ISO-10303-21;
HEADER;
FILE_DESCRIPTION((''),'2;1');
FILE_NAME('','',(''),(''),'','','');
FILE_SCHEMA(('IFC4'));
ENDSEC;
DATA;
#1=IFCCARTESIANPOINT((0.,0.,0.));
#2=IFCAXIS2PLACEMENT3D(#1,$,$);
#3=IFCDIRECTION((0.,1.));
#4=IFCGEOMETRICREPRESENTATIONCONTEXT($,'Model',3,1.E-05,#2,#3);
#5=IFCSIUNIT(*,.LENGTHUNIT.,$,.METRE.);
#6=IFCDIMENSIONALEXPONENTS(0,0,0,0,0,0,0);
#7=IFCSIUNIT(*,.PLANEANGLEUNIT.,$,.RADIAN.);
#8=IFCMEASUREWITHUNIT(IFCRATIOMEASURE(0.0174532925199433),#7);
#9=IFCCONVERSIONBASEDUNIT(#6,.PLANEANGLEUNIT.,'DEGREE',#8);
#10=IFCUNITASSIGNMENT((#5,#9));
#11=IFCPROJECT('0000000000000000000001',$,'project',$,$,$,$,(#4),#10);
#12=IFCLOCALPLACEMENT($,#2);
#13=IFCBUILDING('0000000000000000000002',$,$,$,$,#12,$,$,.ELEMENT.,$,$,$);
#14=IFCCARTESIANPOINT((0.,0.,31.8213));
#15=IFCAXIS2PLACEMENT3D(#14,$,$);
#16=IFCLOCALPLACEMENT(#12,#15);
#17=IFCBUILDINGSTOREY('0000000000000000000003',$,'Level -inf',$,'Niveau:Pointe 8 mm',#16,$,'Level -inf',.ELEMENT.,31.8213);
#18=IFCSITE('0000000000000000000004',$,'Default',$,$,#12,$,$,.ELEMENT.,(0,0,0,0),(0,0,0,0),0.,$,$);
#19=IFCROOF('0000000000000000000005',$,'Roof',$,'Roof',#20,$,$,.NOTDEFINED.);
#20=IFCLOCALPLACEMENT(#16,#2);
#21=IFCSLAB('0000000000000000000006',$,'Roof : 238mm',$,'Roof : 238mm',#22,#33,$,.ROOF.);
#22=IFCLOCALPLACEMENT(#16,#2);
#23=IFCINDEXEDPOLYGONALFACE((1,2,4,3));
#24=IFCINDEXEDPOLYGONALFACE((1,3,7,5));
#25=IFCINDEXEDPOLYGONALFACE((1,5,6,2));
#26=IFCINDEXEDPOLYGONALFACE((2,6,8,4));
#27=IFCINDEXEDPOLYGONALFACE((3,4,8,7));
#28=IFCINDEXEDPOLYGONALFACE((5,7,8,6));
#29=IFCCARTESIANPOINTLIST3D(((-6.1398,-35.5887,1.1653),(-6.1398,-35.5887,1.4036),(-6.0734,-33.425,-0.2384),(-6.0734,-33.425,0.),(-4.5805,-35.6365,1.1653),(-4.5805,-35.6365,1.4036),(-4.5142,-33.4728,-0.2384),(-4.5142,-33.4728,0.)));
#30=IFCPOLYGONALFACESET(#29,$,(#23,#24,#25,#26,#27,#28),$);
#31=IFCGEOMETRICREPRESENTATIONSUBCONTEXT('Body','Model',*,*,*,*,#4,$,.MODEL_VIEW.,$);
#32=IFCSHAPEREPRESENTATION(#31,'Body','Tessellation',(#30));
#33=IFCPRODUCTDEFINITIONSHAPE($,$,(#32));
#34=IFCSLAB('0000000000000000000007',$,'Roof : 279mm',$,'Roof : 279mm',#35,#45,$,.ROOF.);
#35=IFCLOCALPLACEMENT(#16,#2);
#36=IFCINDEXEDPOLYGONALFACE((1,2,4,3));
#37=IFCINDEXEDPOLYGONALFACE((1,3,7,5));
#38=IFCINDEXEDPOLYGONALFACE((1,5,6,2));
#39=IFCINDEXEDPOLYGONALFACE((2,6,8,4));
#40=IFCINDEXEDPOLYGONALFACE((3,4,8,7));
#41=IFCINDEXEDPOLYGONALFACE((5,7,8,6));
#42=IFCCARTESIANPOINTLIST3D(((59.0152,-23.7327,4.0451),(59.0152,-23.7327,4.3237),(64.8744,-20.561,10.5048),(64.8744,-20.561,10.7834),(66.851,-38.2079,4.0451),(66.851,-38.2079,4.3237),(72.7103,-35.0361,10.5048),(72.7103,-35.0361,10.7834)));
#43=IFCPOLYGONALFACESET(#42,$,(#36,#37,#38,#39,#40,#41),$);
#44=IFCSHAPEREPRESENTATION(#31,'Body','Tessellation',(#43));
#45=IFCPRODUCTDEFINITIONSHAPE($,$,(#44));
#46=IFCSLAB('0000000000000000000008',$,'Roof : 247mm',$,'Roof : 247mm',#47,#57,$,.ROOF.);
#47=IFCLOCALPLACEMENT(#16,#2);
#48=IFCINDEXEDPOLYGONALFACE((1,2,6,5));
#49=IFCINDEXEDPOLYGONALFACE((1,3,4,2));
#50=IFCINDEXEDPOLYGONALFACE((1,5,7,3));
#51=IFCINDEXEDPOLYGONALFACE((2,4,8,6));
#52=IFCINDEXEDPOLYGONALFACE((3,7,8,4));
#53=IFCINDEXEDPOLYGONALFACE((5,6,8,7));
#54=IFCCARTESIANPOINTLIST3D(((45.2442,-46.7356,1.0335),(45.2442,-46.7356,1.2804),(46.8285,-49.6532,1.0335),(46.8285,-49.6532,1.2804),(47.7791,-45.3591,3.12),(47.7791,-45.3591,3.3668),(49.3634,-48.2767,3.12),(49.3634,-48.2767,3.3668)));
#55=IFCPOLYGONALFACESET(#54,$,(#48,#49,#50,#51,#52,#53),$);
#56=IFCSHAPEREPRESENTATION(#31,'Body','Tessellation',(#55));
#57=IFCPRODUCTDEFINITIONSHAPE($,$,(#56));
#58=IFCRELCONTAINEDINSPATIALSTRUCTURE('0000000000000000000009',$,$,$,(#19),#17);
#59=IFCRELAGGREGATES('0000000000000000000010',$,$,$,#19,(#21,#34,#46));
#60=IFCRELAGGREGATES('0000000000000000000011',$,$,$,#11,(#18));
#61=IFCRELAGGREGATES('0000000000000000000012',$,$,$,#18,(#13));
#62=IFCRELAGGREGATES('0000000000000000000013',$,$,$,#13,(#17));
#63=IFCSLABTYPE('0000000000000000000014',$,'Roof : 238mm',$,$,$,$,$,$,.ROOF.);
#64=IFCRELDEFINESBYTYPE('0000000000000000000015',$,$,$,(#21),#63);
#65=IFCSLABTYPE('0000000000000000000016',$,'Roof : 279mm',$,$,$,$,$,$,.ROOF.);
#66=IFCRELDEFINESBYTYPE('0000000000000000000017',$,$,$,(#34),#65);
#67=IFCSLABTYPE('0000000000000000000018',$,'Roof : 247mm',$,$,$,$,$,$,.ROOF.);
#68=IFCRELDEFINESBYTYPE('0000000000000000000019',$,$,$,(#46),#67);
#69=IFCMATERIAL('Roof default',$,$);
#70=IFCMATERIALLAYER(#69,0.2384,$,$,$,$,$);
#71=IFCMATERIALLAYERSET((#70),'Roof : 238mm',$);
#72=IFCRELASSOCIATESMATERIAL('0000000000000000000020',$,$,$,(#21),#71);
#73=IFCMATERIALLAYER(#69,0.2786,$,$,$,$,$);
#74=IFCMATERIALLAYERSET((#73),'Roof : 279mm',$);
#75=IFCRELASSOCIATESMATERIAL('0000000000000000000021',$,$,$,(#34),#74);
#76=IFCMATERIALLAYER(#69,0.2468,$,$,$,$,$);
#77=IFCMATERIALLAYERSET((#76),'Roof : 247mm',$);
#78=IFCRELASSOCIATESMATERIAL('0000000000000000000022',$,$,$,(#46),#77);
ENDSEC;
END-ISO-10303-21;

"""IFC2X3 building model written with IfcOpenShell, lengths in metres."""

from ifc_helpers import new_model, entity, si_unit, converted_unit, direction, frame, origin, place, context, subcontext, project, spatial, polyline, outline, extrude, material, layer, layer_set, type_object, element, aggregate, save


model = new_model("IFC2X3")

# Units and contexts
model_context = context("Model", 3, precision=1e-05, world=origin(), true_north=direction((0.0, 1.0)))
body_context = subcontext(model_context, "Body", "Model", "MODEL_VIEW")
ifc_project = project(units=[si_unit("LENGTHUNIT", "METRE"), converted_unit("PLANEANGLEUNIT", "DEGREE", entity("IfcRatioMeasure", 0.0174532925199433), si_unit("PLANEANGLEUNIT", "RADIAN"), dimensions=[0, 0, 0, 0, 0, 0, 0])], contexts=[model_context])

# Site, building, storey
placement_1 = place(None, origin())
site = spatial("IfcSite", under=ifc_project, at=placement_1, Name="Default", CompositionType="ELEMENT", RefLatitude=(0, 0, 0, 0), RefLongitude=(0, 0, 0, 0), RefElevation=0.0)
building = spatial("IfcBuilding", under=site, at=placement_1, CompositionType="ELEMENT")
storey_placement = place(placement_1, frame((0.0, 0.0, 31.8213)))
storey = spatial("IfcBuildingStorey", under=building, at=storey_placement, Name="Level -inf", ObjectType="Niveau:Pointe 8 mm", LongName="Level -inf", CompositionType="ELEMENT", Elevation=31.8213)

# Roof, slabs
placement_2 = place(storey_placement, frame((-6.0734, -33.425, 0.0)))
roof = element("IfcRoof", 1, at=placement_2, inside=storey, Name="Roof", ObjectType="Roof", ShapeType="NOTDEFINED")
ifc_material = material(Name="Roof default")
ifc_layer_1 = layer(ifc_material, 0.2384)
ifc_layer_set_1 = layer_set([ifc_layer_1], Name="Roof : 238mm")
slab_type_1 = type_object("IfcSlabType", Name="Roof : 238mm", PredefinedType="ROOF")
slab_1 = element("IfcSlab", 2, at=placement_2, type_object=slab_type_1, material=ifc_layer_set_1, Name="Roof : 238mm", ObjectType="Roof : 238mm", PredefinedType="ROOF", context=body_context, shape_type="SweptSolid", body=[
    extrude(outline(polyline([(-0.78, 1.29), (0.78, 1.29), (0.78, -1.29), (-0.78, -1.29), (-0.78, 1.29)])), frame((0.7465, -1.1058, 0.7018), z_axis=(0.016677, 0.54379, 0.839056), x_axis=(0.99953, -0.030655, 0.0)), (0.0, 0.544045, -0.839056), 0.2384),
])
ifc_layer_2 = layer(ifc_material, 0.2786)
ifc_layer_set_2 = layer_set([ifc_layer_2], Name="Roof : 279mm")
slab_type_2 = type_object("IfcSlabType", Name="Roof : 279mm", PredefinedType="ROOF")
slab_2 = element("IfcSlab", 3, at=placement_2, type_object=slab_type_2, material=ifc_layer_set_2, Name="Roof : 279mm", ObjectType="Roof : 279mm", PredefinedType="ROOF", context=body_context, shape_type="SweptSolid", body=[
    extrude(outline(polyline([(-8.23, 4.64), (8.23, 4.64), (8.23, -4.64), (-8.23, -4.64), (-8.23, 4.64)])), frame((71.9361, 4.0405, 7.5535), z_axis=(-0.612148, -0.331374, 0.71796), x_axis=(0.476055, -0.879416, 0.0)), (0.0, -0.696085, -0.71796), 0.2786),
])
ifc_layer_3 = layer(ifc_material, 0.2468)
ifc_layer_set_3 = layer_set([ifc_layer_3], Name="Roof : 247mm")
slab_type_3 = type_object("IfcSlabType", Name="Roof : 247mm", PredefinedType="ROOF")
slab_3 = element("IfcSlab", 4, at=placement_2, type_object=slab_type_3, material=ifc_layer_set_3, Name="Roof : 247mm", ObjectType="Roof : 247mm", PredefinedType="ROOF", context=body_context, shape_type="SweptSolid", body=[
    extrude(outline(polyline([(-1.66, -1.78), (1.66, -1.78), (1.66, 1.78), (-1.66, 1.78), (-1.66, -1.78)])), frame((53.3772, -14.0812, 2.3236), z_axis=(-0.515047, -0.279677, 0.810252), x_axis=(0.477197, -0.878797, 0.0)), (0.0, -0.586082, -0.810252), 0.2468),
])
aggregate(roof, [slab_1, slab_2, slab_3])

save(model, "model.ifc")
